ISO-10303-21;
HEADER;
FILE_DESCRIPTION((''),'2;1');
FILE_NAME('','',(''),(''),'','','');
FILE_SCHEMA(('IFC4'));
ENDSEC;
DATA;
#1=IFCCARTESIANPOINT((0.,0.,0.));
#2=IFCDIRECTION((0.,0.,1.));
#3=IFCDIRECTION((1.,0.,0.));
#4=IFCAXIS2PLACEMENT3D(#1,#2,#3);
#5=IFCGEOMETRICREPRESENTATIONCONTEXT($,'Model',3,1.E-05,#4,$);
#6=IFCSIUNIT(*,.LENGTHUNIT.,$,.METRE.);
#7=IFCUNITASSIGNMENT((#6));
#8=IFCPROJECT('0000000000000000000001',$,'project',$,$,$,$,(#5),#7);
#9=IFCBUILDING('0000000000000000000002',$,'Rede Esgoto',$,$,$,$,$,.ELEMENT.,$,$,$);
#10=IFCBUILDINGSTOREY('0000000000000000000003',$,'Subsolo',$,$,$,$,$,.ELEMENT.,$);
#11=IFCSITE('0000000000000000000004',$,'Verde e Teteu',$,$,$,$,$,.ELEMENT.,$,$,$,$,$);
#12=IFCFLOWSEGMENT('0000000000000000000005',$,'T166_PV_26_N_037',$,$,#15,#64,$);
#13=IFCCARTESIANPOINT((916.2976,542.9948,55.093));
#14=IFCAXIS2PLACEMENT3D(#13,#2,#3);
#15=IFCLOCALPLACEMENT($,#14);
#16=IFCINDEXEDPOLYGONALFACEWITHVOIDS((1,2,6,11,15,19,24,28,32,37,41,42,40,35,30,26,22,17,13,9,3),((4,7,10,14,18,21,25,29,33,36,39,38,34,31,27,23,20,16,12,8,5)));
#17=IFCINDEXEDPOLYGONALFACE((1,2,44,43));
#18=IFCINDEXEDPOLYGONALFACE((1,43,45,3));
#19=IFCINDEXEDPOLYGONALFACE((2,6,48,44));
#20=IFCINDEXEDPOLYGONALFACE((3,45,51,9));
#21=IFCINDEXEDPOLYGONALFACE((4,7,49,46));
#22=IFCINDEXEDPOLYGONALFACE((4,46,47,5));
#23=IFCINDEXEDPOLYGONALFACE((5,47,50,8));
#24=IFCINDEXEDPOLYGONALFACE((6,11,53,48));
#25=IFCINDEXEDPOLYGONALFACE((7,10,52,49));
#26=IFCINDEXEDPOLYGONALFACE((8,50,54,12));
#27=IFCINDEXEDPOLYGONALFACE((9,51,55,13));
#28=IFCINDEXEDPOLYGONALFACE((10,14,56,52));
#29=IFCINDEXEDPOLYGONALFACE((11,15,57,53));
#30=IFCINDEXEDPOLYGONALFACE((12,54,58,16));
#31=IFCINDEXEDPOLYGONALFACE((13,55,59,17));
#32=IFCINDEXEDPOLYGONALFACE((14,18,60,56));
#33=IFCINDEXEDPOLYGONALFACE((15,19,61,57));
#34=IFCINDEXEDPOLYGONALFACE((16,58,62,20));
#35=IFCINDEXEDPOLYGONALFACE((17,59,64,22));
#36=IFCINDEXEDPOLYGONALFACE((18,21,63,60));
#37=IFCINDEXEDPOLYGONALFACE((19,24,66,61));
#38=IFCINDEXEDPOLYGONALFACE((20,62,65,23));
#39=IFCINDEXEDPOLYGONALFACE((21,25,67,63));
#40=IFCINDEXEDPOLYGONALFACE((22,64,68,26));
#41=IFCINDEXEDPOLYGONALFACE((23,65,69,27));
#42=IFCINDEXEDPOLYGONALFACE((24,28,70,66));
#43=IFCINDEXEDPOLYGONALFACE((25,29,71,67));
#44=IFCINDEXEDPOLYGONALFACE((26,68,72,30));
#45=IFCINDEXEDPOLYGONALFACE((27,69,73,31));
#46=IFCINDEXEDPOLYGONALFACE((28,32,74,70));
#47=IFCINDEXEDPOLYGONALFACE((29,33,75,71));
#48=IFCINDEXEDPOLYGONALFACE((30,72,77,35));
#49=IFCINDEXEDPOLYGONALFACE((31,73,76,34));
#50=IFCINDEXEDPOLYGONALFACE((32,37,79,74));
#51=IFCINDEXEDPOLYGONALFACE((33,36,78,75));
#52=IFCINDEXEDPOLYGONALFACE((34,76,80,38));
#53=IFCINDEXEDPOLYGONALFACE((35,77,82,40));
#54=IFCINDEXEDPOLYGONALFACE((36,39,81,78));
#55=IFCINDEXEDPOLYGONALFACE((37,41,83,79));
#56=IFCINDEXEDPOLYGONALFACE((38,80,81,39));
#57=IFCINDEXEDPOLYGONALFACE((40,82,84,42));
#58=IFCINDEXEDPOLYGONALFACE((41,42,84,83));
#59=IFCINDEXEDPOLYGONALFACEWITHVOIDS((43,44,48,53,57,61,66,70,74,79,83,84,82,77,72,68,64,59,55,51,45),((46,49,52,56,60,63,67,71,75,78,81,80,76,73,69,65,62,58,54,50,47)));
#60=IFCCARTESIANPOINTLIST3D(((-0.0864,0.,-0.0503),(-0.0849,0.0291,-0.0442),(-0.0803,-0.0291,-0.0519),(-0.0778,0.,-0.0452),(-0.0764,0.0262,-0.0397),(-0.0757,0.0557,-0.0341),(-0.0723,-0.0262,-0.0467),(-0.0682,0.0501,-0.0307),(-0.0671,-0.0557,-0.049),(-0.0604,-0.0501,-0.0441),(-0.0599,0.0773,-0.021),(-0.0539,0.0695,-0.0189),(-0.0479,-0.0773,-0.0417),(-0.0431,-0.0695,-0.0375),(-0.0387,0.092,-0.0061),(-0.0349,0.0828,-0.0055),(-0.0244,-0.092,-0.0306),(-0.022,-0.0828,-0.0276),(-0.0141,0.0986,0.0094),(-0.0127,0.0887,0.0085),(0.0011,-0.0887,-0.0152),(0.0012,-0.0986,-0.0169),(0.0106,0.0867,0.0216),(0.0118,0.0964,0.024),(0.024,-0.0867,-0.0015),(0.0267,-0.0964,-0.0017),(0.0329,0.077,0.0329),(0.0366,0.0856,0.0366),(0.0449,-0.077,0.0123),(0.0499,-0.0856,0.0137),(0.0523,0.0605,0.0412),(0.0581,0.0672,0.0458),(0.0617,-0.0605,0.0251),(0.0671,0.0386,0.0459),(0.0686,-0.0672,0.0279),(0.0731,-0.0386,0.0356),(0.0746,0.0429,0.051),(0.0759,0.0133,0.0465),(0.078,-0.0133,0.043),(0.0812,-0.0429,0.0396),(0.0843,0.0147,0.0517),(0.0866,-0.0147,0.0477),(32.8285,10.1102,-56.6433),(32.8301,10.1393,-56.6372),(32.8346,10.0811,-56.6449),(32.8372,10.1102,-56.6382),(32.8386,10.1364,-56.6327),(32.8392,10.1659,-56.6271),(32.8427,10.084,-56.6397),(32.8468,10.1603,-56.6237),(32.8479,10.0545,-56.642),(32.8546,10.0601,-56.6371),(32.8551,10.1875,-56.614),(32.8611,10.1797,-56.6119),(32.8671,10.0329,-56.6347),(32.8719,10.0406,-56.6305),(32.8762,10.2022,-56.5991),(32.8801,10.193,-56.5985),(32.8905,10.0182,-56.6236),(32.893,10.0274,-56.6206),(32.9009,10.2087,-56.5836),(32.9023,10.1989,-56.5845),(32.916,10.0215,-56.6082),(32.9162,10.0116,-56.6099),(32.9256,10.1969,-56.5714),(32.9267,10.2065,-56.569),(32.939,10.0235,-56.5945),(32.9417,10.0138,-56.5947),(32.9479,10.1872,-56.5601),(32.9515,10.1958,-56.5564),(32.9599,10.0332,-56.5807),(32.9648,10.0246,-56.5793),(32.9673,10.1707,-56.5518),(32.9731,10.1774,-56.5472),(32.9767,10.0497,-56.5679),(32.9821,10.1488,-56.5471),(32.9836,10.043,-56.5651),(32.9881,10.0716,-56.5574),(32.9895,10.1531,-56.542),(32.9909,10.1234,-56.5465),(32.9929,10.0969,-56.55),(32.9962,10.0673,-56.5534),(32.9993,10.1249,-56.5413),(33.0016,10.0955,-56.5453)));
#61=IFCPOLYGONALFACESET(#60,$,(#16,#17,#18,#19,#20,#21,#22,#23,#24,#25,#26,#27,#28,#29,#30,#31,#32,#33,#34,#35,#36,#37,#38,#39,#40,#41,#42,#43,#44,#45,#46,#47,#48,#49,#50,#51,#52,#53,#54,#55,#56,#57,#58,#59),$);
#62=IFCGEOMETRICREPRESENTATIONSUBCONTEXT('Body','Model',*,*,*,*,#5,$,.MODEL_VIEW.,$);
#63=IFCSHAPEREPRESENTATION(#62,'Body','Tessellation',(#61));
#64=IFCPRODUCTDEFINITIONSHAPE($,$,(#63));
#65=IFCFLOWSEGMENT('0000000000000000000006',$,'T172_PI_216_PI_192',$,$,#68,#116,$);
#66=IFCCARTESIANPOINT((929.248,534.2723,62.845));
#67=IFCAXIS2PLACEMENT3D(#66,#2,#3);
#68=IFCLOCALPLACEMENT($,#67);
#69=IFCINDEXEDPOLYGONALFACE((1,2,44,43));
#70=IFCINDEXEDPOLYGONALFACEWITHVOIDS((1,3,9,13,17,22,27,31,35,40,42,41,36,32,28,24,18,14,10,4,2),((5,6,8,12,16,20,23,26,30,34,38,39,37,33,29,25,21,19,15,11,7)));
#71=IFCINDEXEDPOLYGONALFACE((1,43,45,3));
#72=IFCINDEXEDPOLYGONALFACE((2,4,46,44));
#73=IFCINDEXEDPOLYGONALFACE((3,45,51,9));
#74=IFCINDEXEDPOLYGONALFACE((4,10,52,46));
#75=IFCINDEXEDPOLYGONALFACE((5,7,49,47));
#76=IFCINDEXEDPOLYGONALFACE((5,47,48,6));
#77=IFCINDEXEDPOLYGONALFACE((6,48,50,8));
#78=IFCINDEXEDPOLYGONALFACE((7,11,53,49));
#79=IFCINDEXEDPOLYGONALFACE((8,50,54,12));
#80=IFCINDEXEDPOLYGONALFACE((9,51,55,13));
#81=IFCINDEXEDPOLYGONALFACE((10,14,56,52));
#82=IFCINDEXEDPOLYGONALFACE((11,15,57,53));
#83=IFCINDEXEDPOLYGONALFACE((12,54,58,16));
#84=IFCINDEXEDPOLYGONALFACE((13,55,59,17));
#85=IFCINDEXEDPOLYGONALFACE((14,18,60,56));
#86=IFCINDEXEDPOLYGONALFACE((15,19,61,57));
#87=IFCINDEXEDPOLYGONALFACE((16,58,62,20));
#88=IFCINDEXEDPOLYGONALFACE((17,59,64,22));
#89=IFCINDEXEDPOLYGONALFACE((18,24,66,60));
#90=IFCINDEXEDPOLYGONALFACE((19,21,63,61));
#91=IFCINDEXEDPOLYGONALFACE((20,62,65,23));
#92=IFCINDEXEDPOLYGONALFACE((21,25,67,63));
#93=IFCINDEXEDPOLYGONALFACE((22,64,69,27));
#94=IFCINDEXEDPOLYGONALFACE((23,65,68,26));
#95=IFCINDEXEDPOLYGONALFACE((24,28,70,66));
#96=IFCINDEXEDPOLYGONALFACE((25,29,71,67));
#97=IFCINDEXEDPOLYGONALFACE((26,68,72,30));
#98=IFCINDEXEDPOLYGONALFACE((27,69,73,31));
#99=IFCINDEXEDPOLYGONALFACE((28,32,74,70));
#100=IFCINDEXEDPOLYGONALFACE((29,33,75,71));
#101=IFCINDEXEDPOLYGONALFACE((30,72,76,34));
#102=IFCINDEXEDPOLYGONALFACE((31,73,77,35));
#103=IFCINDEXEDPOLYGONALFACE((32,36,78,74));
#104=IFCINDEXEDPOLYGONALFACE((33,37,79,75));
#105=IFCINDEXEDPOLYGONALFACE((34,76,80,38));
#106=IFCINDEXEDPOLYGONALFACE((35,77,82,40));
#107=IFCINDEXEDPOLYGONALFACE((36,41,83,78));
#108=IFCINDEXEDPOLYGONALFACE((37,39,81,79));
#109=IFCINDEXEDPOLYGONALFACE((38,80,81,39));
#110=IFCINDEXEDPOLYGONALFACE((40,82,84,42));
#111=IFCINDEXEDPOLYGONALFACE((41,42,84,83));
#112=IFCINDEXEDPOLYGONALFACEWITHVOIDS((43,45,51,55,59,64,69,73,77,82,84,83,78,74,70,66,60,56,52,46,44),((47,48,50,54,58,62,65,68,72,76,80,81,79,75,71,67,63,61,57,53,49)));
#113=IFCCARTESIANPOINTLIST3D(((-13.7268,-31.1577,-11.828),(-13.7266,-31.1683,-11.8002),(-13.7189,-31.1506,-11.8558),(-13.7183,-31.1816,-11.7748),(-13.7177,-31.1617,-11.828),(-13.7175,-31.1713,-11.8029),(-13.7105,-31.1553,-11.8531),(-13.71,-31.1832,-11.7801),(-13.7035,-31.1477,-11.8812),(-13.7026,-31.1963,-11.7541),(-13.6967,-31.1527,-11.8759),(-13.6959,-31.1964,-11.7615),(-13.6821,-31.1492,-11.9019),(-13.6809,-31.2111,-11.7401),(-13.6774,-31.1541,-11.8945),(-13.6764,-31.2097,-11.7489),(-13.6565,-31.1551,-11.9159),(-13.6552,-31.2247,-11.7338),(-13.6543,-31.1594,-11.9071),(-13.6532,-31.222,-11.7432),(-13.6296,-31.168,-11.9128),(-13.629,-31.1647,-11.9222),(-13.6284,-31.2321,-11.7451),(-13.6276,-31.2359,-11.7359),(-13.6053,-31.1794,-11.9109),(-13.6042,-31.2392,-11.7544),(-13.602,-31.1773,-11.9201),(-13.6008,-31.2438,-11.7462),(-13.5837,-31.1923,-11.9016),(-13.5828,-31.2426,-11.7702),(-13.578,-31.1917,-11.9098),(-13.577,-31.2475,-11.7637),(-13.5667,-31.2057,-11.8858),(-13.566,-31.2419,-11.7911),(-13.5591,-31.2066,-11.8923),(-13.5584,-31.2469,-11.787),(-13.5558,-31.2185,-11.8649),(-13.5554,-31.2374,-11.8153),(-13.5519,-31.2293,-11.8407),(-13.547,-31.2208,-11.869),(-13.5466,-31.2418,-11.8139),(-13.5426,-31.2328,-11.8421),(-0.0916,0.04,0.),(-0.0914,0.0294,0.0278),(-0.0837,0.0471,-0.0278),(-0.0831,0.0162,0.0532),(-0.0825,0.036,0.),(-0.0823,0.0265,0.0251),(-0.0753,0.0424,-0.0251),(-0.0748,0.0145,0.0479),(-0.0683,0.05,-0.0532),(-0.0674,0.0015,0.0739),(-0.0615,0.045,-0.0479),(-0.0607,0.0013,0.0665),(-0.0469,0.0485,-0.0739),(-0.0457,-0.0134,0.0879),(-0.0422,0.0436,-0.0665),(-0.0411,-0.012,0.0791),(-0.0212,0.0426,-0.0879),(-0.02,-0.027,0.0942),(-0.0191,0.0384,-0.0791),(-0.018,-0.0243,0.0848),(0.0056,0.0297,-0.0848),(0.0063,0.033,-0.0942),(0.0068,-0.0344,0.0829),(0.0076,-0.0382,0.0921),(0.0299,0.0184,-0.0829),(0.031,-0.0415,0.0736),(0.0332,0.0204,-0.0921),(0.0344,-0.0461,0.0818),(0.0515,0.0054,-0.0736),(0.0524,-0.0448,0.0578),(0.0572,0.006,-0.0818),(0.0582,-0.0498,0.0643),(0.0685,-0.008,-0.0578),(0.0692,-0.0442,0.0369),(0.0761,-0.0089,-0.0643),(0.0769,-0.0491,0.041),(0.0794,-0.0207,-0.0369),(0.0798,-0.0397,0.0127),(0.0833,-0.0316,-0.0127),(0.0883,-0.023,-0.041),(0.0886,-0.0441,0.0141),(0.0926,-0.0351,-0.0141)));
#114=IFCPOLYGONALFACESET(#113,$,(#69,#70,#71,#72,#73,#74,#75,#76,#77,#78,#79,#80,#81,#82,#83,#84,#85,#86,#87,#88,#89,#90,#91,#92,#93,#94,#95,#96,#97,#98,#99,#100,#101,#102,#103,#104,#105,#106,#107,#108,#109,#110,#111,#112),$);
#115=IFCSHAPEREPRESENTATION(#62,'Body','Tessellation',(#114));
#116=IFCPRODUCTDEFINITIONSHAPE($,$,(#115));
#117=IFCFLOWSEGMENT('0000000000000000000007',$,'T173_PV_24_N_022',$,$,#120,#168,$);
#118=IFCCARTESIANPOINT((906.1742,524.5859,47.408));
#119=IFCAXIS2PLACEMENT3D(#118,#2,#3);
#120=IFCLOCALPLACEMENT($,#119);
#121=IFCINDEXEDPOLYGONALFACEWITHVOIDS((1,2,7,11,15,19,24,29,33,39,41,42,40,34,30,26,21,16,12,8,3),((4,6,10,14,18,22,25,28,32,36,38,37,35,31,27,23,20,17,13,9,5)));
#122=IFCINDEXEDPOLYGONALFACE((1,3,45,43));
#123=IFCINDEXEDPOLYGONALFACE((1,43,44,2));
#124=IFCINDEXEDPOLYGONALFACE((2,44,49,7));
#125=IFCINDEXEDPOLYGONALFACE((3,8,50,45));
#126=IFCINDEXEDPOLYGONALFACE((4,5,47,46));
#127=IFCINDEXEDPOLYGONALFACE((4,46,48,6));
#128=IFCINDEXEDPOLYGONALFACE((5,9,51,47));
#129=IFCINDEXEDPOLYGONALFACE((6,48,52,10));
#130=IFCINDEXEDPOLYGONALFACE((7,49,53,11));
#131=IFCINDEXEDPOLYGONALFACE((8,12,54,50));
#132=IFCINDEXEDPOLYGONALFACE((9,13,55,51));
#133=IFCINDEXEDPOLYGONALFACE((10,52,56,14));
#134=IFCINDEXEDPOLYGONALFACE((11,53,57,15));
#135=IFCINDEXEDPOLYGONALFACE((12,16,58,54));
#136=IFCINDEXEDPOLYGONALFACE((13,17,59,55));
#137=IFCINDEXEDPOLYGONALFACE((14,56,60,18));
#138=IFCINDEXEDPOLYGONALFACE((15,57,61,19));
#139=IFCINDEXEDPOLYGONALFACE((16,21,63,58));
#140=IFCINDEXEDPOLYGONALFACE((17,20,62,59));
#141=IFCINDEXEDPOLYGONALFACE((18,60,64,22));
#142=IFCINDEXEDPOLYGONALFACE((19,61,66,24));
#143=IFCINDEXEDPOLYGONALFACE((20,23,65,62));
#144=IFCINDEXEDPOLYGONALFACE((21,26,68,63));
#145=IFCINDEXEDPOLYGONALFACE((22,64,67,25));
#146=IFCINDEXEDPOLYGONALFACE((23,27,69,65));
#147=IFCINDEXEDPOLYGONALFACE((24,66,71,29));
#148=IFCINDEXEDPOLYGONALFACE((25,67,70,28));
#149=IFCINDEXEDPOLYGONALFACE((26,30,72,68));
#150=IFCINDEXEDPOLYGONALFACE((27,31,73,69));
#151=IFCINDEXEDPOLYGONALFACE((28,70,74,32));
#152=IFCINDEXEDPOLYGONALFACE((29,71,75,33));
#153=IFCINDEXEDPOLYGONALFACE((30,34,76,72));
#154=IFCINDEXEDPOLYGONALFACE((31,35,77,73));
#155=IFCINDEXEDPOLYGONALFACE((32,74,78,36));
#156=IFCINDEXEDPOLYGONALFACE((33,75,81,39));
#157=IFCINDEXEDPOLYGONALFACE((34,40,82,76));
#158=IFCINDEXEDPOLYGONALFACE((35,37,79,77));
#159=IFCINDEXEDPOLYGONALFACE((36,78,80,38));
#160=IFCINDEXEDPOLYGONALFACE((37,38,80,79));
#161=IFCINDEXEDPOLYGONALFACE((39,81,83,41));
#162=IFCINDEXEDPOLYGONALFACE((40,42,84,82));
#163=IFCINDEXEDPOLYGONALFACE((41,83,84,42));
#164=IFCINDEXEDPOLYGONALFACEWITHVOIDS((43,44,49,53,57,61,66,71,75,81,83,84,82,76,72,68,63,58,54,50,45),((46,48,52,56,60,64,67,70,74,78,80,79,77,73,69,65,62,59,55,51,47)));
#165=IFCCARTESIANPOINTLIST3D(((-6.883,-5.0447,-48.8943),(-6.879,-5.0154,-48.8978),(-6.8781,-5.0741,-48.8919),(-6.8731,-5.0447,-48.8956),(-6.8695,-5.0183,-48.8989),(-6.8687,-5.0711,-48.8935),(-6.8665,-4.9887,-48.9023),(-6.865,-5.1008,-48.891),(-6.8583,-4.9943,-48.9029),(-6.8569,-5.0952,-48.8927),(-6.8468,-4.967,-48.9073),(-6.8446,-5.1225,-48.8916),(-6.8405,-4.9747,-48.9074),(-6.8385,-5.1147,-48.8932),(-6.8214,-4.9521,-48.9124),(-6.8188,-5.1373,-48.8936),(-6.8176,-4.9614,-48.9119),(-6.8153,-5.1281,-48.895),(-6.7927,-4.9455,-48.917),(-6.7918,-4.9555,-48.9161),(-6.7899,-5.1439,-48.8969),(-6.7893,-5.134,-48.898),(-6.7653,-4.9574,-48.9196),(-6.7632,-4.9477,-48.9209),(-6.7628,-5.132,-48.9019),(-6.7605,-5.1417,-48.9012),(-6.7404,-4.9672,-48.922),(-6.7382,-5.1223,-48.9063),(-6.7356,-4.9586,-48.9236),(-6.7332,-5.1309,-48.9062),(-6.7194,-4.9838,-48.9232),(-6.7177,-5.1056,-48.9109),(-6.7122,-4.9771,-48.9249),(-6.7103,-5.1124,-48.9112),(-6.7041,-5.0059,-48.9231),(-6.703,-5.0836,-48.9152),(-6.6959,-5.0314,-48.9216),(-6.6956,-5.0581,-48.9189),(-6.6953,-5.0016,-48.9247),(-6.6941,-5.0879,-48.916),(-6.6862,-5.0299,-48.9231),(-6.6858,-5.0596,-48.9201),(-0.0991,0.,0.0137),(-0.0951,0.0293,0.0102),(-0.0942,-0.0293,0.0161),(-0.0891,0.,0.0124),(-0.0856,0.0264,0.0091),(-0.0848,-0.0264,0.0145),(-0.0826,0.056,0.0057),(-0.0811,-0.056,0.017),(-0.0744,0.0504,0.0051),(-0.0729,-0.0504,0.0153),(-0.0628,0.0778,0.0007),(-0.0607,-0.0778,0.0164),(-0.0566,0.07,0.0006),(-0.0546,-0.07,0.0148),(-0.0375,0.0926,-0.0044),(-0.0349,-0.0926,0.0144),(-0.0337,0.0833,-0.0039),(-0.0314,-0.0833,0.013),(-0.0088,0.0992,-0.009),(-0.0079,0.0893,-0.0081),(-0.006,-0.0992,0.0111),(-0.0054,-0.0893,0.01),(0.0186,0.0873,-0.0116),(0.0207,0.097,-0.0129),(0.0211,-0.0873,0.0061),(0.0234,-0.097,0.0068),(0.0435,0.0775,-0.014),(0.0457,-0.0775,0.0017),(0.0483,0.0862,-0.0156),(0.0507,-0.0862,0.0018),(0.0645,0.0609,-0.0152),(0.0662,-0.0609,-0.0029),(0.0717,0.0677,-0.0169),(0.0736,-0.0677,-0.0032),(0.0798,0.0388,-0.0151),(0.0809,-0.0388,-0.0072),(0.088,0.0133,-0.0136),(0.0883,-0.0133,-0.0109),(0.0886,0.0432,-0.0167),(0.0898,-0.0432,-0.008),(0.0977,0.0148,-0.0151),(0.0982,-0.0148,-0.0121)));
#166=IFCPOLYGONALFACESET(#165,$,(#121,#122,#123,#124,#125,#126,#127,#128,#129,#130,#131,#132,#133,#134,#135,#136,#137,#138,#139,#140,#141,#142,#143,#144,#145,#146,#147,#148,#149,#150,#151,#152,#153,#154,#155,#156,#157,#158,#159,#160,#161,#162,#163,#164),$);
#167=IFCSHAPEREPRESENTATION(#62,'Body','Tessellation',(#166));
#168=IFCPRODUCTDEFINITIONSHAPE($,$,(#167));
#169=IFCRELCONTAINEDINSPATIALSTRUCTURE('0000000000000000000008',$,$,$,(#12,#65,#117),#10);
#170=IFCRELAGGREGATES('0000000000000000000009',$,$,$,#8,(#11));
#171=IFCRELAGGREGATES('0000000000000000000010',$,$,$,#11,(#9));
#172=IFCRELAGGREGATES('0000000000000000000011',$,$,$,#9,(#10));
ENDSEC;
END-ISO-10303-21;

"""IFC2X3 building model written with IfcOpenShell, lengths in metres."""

from ifc_helpers import new_model, entity, si_unit, frame, origin_with_axes, place, context, subcontext, project, spatial, element, save


model = new_model("IFC2X3")

# Units and contexts
model_context = context("Model", 3, precision=1e-05, world=origin_with_axes())
body_context = subcontext(model_context, "Body", "Model", "MODEL_VIEW")
ifc_project = project(units=[si_unit("LENGTHUNIT", "METRE")], contexts=[model_context])

# Site, building, storey
site = spatial("IfcSite", under=ifc_project, Name="Verde e Teteu", CompositionType="ELEMENT")
building = spatial("IfcBuilding", under=site, Name="Rede Esgoto", CompositionType="ELEMENT")
storey = spatial("IfcBuildingStorey", under=building, Name="Subsolo", CompositionType="ELEMENT")

# Flow segments
flow_segment_1_placement = place(None, frame((916.2976, 542.9948, 55.093), z_axis=(0.0, 0.0, 1.0), x_axis=(1.0, 0.0, 0.0)))
element("IfcFlowSegment", 1, at=flow_segment_1_placement, inside=storey, Name="T166_PV_26_N_037", context=body_context, shape_type="SweptSolid", body=[
    entity("IfcSweptDiskSolid", entity("IfcPolyline", [entity("IfcCartesianPoint", [0.0, 0.0, 0.0]), entity("IfcCartesianPoint", [32.915, 10.1102, -56.593])]), 0.1, 0.09),
])
flow_segment_2_placement = place(None, frame((929.248, 534.2723, 62.845), z_axis=(0.0, 0.0, 1.0), x_axis=(1.0, 0.0, 0.0)))
element("IfcFlowSegment", 2, at=flow_segment_2_placement, inside=storey, Name="T172_PI_216_PI_192", context=body_context, shape_type="SweptSolid", body=[
    entity("IfcSweptDiskSolid", entity("IfcPolyline", [entity("IfcCartesianPoint", [0.0, 0.0, 0.0]), entity("IfcCartesianPoint", [-13.6352, -31.1977, -11.828])]), 0.1, 0.09),
])
flow_segment_3_placement = place(None, frame((906.1742, 524.5859, 47.408), z_axis=(0.0, 0.0, 1.0), x_axis=(1.0, 0.0, 0.0)))
element("IfcFlowSegment", 3, at=flow_segment_3_placement, inside=storey, Name="T173_PV_24_N_022", context=body_context, shape_type="SweptSolid", body=[
    entity("IfcSweptDiskSolid", entity("IfcPolyline", [entity("IfcCartesianPoint", [0.0, 0.0, 0.0]), entity("IfcCartesianPoint", [-6.7839, -5.0447, -48.908])]), 0.1, 0.09),
])

save(model, "model.ifc")
